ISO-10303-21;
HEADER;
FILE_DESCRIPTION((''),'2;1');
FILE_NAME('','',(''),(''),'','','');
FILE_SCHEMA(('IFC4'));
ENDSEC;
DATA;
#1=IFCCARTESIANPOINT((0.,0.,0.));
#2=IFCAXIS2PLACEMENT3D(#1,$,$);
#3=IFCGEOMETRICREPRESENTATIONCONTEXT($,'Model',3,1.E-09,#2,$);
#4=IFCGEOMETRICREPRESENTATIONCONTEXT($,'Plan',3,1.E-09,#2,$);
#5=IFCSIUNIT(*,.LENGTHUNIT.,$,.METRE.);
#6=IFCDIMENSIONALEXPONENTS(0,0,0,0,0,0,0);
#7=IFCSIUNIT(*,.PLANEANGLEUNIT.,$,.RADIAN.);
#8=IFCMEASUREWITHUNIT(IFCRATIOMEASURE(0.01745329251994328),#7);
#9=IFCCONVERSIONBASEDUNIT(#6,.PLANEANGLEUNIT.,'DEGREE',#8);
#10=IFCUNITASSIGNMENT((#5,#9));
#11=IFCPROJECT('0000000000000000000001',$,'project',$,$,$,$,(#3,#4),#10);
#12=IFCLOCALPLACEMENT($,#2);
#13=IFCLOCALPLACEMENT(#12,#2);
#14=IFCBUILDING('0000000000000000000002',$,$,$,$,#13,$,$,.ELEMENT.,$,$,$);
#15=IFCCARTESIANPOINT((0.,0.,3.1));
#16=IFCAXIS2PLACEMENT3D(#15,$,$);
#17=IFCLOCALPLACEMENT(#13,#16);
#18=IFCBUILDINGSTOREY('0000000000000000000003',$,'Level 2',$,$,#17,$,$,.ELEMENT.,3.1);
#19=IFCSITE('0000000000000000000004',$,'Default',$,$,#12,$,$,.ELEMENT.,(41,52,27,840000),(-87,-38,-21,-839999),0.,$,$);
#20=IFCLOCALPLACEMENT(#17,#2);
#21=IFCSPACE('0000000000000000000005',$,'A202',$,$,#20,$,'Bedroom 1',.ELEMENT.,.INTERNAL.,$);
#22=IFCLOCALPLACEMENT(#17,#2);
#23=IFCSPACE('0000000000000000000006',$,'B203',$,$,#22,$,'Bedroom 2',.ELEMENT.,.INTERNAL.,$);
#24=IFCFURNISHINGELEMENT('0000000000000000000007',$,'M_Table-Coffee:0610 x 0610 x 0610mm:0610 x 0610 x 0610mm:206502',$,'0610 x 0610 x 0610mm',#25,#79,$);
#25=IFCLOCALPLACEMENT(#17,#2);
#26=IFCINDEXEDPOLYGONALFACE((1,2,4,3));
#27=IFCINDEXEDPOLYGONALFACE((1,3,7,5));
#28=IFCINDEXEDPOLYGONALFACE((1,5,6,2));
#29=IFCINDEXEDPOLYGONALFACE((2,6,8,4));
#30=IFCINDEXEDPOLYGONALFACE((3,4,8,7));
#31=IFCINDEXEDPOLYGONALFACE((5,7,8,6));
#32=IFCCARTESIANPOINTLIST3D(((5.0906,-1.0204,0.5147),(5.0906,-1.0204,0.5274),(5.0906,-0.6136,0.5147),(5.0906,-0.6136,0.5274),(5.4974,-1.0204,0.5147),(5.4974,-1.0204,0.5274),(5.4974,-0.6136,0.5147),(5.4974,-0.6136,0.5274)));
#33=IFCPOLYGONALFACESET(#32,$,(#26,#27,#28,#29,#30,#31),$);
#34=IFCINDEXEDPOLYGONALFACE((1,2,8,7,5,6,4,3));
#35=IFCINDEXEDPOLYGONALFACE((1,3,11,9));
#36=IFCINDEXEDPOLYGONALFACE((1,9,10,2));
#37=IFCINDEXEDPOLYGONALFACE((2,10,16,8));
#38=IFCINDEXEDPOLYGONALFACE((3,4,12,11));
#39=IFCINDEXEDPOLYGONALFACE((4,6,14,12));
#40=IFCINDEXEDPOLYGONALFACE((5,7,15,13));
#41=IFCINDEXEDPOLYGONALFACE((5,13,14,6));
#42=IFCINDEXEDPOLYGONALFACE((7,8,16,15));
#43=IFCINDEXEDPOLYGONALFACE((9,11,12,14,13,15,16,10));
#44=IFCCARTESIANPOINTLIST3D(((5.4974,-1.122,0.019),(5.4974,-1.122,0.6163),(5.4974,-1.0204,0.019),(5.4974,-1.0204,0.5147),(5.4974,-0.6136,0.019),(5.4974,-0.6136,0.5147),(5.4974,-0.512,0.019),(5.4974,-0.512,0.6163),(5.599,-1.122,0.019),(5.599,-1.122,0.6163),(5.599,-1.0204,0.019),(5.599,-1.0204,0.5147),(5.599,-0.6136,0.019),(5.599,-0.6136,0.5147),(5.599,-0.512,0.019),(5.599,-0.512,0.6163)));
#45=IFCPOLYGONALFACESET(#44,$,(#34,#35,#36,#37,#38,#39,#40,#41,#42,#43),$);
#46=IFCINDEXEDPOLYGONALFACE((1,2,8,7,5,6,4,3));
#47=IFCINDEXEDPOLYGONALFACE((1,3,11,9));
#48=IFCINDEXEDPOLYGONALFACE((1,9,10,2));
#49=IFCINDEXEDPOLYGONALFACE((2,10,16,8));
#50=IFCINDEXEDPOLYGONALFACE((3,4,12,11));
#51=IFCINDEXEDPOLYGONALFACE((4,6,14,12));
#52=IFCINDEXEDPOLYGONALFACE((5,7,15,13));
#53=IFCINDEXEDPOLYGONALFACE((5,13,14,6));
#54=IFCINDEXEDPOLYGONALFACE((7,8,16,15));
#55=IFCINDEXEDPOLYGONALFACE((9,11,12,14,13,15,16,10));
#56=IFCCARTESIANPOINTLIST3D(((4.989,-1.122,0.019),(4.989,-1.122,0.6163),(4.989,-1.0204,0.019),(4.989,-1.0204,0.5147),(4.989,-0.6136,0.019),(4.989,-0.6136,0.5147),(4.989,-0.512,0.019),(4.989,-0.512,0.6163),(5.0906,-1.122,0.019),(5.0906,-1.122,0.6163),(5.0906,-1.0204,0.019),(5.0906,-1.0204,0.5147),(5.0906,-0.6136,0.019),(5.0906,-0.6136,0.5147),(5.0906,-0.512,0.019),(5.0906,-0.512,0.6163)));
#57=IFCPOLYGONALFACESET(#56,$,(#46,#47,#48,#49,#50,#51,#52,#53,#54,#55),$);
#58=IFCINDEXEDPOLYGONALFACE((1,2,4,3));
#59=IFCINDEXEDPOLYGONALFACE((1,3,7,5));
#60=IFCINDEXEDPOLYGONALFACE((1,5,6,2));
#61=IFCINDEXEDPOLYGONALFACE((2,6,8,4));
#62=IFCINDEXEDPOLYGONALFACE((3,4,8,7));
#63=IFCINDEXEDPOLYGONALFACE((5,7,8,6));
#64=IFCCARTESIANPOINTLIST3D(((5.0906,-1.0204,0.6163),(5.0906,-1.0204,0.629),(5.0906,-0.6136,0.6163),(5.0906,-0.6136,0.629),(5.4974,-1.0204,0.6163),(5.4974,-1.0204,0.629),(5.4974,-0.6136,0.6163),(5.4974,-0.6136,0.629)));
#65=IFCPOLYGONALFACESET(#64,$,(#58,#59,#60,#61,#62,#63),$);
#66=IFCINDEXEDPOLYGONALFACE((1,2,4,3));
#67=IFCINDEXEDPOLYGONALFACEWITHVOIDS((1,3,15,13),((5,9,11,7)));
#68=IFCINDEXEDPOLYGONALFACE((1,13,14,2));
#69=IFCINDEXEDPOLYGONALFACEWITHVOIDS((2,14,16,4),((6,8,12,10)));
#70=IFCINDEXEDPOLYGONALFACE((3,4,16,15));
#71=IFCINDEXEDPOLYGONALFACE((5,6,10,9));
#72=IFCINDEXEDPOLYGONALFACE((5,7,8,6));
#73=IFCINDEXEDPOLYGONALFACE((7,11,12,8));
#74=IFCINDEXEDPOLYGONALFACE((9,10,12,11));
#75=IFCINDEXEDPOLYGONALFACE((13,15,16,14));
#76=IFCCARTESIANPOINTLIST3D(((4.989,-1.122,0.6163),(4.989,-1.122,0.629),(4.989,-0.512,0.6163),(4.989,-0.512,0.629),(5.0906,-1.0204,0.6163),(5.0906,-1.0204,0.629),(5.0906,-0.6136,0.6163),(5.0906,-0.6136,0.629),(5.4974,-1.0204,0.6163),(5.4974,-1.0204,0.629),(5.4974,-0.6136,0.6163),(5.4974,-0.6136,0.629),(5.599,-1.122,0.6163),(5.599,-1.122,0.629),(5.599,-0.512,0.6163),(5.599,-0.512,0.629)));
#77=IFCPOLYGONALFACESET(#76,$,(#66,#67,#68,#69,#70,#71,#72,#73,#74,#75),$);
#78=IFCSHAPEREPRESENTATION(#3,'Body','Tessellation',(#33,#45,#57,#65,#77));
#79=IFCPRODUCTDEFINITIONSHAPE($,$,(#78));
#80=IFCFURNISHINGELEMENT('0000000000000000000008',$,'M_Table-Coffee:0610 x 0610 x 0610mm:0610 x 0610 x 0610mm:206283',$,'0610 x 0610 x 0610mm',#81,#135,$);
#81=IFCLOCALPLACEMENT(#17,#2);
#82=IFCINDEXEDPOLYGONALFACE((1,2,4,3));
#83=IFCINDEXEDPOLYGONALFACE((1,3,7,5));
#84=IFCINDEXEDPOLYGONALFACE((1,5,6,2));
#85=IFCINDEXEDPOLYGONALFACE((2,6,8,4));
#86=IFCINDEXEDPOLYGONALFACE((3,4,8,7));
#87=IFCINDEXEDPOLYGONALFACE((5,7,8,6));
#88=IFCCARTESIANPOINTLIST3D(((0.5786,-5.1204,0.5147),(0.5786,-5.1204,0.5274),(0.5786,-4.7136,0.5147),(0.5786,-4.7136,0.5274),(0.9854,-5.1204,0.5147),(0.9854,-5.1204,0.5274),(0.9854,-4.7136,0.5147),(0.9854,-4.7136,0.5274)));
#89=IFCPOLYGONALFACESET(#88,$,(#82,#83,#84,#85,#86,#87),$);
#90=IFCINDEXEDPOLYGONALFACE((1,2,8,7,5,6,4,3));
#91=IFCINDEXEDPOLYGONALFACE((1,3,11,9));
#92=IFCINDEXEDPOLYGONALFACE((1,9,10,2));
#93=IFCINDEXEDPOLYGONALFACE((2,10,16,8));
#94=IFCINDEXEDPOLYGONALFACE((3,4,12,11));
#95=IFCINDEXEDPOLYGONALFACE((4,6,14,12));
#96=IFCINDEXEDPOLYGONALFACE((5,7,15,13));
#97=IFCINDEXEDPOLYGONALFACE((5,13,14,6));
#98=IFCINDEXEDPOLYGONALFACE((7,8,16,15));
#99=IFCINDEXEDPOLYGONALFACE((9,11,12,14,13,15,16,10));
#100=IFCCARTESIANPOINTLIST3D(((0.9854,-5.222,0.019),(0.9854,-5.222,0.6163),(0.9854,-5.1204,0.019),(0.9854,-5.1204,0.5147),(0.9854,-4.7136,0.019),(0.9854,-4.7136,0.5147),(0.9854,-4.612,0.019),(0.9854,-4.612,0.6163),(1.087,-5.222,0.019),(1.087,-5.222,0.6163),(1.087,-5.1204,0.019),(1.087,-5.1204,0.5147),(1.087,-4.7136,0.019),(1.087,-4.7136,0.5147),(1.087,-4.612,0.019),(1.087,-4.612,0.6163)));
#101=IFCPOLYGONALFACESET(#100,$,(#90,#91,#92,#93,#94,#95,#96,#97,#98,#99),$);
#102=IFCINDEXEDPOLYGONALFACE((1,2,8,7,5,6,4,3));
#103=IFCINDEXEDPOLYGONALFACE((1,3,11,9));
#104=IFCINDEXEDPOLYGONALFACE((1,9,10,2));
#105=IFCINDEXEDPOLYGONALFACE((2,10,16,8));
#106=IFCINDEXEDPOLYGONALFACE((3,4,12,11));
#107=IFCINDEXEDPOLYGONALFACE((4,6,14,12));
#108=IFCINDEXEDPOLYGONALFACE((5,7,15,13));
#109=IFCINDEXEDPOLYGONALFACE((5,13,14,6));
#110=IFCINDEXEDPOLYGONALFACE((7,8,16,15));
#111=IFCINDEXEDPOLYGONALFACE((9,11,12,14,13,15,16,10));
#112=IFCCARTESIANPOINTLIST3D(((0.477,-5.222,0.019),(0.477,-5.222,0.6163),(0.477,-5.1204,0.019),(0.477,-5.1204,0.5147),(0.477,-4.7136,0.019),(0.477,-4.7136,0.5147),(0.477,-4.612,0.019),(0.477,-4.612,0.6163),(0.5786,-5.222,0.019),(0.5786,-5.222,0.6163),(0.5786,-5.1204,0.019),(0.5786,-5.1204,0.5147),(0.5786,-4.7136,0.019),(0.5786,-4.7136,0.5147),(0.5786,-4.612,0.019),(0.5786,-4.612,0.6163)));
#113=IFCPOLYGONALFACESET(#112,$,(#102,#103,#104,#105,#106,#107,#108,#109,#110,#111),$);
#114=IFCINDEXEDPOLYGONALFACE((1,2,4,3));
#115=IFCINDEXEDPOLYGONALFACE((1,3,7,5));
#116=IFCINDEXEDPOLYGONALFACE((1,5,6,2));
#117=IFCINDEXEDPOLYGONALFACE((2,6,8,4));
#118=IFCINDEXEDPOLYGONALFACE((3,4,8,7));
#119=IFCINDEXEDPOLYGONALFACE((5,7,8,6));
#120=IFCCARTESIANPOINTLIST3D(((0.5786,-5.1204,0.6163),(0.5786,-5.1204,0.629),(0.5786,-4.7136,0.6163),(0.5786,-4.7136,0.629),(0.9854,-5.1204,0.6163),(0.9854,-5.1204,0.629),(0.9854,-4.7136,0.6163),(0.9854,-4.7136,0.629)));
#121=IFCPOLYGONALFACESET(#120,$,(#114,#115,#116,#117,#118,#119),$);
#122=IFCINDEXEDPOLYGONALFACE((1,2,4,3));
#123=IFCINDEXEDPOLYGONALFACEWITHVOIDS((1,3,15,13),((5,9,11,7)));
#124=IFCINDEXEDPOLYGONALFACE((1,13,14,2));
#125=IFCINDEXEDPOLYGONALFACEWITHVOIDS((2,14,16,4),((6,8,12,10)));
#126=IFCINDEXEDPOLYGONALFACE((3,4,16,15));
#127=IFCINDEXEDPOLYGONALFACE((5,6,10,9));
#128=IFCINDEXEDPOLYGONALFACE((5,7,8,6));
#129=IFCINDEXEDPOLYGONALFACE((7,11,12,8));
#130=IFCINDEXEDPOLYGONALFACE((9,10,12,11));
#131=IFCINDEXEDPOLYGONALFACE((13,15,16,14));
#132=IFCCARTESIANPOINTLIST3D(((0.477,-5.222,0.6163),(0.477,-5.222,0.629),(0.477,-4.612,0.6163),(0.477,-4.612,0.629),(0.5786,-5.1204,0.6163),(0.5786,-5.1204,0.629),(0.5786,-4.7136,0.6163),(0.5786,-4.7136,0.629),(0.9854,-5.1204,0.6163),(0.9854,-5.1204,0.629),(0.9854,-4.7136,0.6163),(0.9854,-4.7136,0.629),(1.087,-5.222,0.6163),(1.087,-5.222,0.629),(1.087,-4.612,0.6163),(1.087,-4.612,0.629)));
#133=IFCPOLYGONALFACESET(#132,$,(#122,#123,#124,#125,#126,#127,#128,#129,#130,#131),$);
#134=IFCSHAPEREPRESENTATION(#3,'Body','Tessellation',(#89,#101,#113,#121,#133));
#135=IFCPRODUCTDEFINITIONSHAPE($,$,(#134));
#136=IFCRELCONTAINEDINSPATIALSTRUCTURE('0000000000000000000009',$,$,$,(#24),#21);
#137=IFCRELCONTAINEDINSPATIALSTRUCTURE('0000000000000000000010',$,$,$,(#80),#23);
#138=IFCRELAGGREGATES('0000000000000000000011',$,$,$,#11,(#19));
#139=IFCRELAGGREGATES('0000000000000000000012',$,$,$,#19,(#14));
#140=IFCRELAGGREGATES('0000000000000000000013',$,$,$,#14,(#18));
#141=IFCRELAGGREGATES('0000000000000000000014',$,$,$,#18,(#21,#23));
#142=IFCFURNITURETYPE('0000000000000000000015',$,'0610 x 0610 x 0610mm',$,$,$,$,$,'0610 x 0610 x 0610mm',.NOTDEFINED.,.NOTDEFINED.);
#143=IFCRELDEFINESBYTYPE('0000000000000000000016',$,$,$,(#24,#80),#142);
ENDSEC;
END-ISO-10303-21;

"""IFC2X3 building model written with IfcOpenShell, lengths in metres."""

from ifc_helpers import new_model, entity, si_unit, converted_unit, frame, origin, origin_2d_with_axis, place, context, project, spatial, polyline, rectangle, outline, extrude, source, transform, mapped, type_object, type_shapes, element, save


model = new_model("IFC2X3")

# Units and contexts
model_context = context("Model", 3, precision=1e-09, world=origin())
plan_context = context("Plan", 3, precision=1e-09, world=origin())
ifc_project = project(units=[si_unit("LENGTHUNIT", "METRE"), converted_unit("PLANEANGLEUNIT", "DEGREE", entity("IfcRatioMeasure", 0.01745329251994328), si_unit("PLANEANGLEUNIT", "RADIAN"), dimensions=[0, 0, 0, 0, 0, 0, 0])], contexts=[model_context, plan_context])

# Site, building, storey
site_placement = place(None, origin())
site = spatial("IfcSite", under=ifc_project, at=site_placement, Name="Default", CompositionType="ELEMENT", RefLatitude=(41, 52, 27, 840000), RefLongitude=(-87, -38, -21, -839999), RefElevation=0.0)
building_placement = place(site_placement, origin())
building = spatial("IfcBuilding", under=site, at=building_placement, CompositionType="ELEMENT")
storey_placement = place(building_placement, frame((0.0, 0.0, 3.1)))
storey = spatial("IfcBuildingStorey", under=building, at=storey_placement, Name="Level 2", CompositionType="ELEMENT", Elevation=3.1)

# Shared definitions
space_1_placement = place(storey_placement, origin())
space_1 = spatial("IfcSpace", under=storey, at=space_1_placement, Name="A202", LongName="Bedroom 1", CompositionType="ELEMENT", InteriorOrExteriorSpace="INTERNAL")

# Furnishing element
furniture_type = type_object("IfcFurnitureType", Name="0610 x 0610 x 0610mm", ElementType="0610 x 0610 x 0610mm", AssemblyPlace="NOTDEFINED")
shared_shape_1 = source(origin(), model_context, "Body", "SweptSolid", [
    extrude(rectangle(XDim=0.4068, YDim=0.4068, at=origin_2d_with_axis()), frame((0.0183, 0.0952, 0.4957), z_axis=(0.0, 0.0, 1.0), x_axis=(-1.0, 0.0, 0.0)), (0.0, 0.0, 1.0), 0.0127),
    extrude(outline(polyline([(-0.2732, -0.305), (0.324, -0.305), (0.324, 0.305), (-0.2732, 0.305), (-0.2732, 0.2034), (0.2225, 0.2034), (0.2225, -0.2034), (-0.2732, -0.2034), (-0.2732, -0.305)])), frame((0.2217, 0.0952, 0.2732), z_axis=(1.0, 0.0, 0.0), x_axis=(0.0, 0.0, 1.0)), (0.0, 0.0, 1.0), 0.1016),
    extrude(outline(polyline([(-0.305, -0.3241), (0.305, -0.3241), (0.305, 0.2733), (0.2034, 0.2733), (0.2034, -0.2224), (-0.2034, -0.2224), (-0.2034, 0.2733), (-0.305, 0.2733), (-0.305, -0.3241)])), frame((-0.2867, 0.0952, 0.2733), z_axis=(1.0, 0.0, 0.0), x_axis=(0.0, -1.0, 0.0)), (0.0, 0.0, 1.0), 0.1016),
    extrude(rectangle(XDim=0.4068, YDim=0.4068, at=origin_2d_with_axis()), frame((0.0183, 0.0952, 0.5973), z_axis=(0.0, 0.0, 1.0), x_axis=(-1.0, 0.0, 0.0)), (0.0, 0.0, 1.0), 0.0127),
    extrude(outline(polyline([(-0.305, -0.305), (0.305, -0.305), (0.305, 0.305), (-0.305, 0.305), (-0.305, -0.305)]), holes=[polyline([(-0.2034, -0.2034), (-0.2034, 0.2034), (0.2034, 0.2034), (0.2034, -0.2034), (-0.2034, -0.2034)])]), frame((0.0183, 0.0952, 0.5973), z_axis=(0.0, 0.0, 1.0), x_axis=(-1.0, 0.0, 0.0)), (0.0, 0.0, 1.0), 0.0127),
])
type_shapes(furniture_type, [shared_shape_1])
furnishing_1_placement = place(space_1_placement, frame((5.2757, -0.9122, 0.019)))
element("IfcFurnishingElement", 1, at=furnishing_1_placement, inside=space_1, type_object=furniture_type, Name="M_Table-Coffee:0610 x 0610 x 0610mm:0610 x 0610 x 0610mm:206502", ObjectType="0610 x 0610 x 0610mm", context=model_context, shape_type="MappedRepresentation", body=[
    mapped(shared_shape_1, transform((0.0, 0.0, 0.0), scale=1.0)),
])

# Shared definitions
space_2_placement = place(storey_placement, origin())
space_2 = spatial("IfcSpace", under=storey, at=space_2_placement, Name="B203", LongName="Bedroom 2", CompositionType="ELEMENT", InteriorOrExteriorSpace="INTERNAL")

# Furnishing element
furnishing_2_placement = place(space_2_placement, frame((0.7637, -5.0122, 0.019)))
element("IfcFurnishingElement", 2, at=furnishing_2_placement, inside=space_2, type_object=furniture_type, Name="M_Table-Coffee:0610 x 0610 x 0610mm:0610 x 0610 x 0610mm:206283", ObjectType="0610 x 0610 x 0610mm", context=model_context, shape_type="MappedRepresentation", body=[
    mapped(shared_shape_1, transform((0.0, 0.0, 0.0), scale=1.0)),
])

save(model, "model.ifc")
